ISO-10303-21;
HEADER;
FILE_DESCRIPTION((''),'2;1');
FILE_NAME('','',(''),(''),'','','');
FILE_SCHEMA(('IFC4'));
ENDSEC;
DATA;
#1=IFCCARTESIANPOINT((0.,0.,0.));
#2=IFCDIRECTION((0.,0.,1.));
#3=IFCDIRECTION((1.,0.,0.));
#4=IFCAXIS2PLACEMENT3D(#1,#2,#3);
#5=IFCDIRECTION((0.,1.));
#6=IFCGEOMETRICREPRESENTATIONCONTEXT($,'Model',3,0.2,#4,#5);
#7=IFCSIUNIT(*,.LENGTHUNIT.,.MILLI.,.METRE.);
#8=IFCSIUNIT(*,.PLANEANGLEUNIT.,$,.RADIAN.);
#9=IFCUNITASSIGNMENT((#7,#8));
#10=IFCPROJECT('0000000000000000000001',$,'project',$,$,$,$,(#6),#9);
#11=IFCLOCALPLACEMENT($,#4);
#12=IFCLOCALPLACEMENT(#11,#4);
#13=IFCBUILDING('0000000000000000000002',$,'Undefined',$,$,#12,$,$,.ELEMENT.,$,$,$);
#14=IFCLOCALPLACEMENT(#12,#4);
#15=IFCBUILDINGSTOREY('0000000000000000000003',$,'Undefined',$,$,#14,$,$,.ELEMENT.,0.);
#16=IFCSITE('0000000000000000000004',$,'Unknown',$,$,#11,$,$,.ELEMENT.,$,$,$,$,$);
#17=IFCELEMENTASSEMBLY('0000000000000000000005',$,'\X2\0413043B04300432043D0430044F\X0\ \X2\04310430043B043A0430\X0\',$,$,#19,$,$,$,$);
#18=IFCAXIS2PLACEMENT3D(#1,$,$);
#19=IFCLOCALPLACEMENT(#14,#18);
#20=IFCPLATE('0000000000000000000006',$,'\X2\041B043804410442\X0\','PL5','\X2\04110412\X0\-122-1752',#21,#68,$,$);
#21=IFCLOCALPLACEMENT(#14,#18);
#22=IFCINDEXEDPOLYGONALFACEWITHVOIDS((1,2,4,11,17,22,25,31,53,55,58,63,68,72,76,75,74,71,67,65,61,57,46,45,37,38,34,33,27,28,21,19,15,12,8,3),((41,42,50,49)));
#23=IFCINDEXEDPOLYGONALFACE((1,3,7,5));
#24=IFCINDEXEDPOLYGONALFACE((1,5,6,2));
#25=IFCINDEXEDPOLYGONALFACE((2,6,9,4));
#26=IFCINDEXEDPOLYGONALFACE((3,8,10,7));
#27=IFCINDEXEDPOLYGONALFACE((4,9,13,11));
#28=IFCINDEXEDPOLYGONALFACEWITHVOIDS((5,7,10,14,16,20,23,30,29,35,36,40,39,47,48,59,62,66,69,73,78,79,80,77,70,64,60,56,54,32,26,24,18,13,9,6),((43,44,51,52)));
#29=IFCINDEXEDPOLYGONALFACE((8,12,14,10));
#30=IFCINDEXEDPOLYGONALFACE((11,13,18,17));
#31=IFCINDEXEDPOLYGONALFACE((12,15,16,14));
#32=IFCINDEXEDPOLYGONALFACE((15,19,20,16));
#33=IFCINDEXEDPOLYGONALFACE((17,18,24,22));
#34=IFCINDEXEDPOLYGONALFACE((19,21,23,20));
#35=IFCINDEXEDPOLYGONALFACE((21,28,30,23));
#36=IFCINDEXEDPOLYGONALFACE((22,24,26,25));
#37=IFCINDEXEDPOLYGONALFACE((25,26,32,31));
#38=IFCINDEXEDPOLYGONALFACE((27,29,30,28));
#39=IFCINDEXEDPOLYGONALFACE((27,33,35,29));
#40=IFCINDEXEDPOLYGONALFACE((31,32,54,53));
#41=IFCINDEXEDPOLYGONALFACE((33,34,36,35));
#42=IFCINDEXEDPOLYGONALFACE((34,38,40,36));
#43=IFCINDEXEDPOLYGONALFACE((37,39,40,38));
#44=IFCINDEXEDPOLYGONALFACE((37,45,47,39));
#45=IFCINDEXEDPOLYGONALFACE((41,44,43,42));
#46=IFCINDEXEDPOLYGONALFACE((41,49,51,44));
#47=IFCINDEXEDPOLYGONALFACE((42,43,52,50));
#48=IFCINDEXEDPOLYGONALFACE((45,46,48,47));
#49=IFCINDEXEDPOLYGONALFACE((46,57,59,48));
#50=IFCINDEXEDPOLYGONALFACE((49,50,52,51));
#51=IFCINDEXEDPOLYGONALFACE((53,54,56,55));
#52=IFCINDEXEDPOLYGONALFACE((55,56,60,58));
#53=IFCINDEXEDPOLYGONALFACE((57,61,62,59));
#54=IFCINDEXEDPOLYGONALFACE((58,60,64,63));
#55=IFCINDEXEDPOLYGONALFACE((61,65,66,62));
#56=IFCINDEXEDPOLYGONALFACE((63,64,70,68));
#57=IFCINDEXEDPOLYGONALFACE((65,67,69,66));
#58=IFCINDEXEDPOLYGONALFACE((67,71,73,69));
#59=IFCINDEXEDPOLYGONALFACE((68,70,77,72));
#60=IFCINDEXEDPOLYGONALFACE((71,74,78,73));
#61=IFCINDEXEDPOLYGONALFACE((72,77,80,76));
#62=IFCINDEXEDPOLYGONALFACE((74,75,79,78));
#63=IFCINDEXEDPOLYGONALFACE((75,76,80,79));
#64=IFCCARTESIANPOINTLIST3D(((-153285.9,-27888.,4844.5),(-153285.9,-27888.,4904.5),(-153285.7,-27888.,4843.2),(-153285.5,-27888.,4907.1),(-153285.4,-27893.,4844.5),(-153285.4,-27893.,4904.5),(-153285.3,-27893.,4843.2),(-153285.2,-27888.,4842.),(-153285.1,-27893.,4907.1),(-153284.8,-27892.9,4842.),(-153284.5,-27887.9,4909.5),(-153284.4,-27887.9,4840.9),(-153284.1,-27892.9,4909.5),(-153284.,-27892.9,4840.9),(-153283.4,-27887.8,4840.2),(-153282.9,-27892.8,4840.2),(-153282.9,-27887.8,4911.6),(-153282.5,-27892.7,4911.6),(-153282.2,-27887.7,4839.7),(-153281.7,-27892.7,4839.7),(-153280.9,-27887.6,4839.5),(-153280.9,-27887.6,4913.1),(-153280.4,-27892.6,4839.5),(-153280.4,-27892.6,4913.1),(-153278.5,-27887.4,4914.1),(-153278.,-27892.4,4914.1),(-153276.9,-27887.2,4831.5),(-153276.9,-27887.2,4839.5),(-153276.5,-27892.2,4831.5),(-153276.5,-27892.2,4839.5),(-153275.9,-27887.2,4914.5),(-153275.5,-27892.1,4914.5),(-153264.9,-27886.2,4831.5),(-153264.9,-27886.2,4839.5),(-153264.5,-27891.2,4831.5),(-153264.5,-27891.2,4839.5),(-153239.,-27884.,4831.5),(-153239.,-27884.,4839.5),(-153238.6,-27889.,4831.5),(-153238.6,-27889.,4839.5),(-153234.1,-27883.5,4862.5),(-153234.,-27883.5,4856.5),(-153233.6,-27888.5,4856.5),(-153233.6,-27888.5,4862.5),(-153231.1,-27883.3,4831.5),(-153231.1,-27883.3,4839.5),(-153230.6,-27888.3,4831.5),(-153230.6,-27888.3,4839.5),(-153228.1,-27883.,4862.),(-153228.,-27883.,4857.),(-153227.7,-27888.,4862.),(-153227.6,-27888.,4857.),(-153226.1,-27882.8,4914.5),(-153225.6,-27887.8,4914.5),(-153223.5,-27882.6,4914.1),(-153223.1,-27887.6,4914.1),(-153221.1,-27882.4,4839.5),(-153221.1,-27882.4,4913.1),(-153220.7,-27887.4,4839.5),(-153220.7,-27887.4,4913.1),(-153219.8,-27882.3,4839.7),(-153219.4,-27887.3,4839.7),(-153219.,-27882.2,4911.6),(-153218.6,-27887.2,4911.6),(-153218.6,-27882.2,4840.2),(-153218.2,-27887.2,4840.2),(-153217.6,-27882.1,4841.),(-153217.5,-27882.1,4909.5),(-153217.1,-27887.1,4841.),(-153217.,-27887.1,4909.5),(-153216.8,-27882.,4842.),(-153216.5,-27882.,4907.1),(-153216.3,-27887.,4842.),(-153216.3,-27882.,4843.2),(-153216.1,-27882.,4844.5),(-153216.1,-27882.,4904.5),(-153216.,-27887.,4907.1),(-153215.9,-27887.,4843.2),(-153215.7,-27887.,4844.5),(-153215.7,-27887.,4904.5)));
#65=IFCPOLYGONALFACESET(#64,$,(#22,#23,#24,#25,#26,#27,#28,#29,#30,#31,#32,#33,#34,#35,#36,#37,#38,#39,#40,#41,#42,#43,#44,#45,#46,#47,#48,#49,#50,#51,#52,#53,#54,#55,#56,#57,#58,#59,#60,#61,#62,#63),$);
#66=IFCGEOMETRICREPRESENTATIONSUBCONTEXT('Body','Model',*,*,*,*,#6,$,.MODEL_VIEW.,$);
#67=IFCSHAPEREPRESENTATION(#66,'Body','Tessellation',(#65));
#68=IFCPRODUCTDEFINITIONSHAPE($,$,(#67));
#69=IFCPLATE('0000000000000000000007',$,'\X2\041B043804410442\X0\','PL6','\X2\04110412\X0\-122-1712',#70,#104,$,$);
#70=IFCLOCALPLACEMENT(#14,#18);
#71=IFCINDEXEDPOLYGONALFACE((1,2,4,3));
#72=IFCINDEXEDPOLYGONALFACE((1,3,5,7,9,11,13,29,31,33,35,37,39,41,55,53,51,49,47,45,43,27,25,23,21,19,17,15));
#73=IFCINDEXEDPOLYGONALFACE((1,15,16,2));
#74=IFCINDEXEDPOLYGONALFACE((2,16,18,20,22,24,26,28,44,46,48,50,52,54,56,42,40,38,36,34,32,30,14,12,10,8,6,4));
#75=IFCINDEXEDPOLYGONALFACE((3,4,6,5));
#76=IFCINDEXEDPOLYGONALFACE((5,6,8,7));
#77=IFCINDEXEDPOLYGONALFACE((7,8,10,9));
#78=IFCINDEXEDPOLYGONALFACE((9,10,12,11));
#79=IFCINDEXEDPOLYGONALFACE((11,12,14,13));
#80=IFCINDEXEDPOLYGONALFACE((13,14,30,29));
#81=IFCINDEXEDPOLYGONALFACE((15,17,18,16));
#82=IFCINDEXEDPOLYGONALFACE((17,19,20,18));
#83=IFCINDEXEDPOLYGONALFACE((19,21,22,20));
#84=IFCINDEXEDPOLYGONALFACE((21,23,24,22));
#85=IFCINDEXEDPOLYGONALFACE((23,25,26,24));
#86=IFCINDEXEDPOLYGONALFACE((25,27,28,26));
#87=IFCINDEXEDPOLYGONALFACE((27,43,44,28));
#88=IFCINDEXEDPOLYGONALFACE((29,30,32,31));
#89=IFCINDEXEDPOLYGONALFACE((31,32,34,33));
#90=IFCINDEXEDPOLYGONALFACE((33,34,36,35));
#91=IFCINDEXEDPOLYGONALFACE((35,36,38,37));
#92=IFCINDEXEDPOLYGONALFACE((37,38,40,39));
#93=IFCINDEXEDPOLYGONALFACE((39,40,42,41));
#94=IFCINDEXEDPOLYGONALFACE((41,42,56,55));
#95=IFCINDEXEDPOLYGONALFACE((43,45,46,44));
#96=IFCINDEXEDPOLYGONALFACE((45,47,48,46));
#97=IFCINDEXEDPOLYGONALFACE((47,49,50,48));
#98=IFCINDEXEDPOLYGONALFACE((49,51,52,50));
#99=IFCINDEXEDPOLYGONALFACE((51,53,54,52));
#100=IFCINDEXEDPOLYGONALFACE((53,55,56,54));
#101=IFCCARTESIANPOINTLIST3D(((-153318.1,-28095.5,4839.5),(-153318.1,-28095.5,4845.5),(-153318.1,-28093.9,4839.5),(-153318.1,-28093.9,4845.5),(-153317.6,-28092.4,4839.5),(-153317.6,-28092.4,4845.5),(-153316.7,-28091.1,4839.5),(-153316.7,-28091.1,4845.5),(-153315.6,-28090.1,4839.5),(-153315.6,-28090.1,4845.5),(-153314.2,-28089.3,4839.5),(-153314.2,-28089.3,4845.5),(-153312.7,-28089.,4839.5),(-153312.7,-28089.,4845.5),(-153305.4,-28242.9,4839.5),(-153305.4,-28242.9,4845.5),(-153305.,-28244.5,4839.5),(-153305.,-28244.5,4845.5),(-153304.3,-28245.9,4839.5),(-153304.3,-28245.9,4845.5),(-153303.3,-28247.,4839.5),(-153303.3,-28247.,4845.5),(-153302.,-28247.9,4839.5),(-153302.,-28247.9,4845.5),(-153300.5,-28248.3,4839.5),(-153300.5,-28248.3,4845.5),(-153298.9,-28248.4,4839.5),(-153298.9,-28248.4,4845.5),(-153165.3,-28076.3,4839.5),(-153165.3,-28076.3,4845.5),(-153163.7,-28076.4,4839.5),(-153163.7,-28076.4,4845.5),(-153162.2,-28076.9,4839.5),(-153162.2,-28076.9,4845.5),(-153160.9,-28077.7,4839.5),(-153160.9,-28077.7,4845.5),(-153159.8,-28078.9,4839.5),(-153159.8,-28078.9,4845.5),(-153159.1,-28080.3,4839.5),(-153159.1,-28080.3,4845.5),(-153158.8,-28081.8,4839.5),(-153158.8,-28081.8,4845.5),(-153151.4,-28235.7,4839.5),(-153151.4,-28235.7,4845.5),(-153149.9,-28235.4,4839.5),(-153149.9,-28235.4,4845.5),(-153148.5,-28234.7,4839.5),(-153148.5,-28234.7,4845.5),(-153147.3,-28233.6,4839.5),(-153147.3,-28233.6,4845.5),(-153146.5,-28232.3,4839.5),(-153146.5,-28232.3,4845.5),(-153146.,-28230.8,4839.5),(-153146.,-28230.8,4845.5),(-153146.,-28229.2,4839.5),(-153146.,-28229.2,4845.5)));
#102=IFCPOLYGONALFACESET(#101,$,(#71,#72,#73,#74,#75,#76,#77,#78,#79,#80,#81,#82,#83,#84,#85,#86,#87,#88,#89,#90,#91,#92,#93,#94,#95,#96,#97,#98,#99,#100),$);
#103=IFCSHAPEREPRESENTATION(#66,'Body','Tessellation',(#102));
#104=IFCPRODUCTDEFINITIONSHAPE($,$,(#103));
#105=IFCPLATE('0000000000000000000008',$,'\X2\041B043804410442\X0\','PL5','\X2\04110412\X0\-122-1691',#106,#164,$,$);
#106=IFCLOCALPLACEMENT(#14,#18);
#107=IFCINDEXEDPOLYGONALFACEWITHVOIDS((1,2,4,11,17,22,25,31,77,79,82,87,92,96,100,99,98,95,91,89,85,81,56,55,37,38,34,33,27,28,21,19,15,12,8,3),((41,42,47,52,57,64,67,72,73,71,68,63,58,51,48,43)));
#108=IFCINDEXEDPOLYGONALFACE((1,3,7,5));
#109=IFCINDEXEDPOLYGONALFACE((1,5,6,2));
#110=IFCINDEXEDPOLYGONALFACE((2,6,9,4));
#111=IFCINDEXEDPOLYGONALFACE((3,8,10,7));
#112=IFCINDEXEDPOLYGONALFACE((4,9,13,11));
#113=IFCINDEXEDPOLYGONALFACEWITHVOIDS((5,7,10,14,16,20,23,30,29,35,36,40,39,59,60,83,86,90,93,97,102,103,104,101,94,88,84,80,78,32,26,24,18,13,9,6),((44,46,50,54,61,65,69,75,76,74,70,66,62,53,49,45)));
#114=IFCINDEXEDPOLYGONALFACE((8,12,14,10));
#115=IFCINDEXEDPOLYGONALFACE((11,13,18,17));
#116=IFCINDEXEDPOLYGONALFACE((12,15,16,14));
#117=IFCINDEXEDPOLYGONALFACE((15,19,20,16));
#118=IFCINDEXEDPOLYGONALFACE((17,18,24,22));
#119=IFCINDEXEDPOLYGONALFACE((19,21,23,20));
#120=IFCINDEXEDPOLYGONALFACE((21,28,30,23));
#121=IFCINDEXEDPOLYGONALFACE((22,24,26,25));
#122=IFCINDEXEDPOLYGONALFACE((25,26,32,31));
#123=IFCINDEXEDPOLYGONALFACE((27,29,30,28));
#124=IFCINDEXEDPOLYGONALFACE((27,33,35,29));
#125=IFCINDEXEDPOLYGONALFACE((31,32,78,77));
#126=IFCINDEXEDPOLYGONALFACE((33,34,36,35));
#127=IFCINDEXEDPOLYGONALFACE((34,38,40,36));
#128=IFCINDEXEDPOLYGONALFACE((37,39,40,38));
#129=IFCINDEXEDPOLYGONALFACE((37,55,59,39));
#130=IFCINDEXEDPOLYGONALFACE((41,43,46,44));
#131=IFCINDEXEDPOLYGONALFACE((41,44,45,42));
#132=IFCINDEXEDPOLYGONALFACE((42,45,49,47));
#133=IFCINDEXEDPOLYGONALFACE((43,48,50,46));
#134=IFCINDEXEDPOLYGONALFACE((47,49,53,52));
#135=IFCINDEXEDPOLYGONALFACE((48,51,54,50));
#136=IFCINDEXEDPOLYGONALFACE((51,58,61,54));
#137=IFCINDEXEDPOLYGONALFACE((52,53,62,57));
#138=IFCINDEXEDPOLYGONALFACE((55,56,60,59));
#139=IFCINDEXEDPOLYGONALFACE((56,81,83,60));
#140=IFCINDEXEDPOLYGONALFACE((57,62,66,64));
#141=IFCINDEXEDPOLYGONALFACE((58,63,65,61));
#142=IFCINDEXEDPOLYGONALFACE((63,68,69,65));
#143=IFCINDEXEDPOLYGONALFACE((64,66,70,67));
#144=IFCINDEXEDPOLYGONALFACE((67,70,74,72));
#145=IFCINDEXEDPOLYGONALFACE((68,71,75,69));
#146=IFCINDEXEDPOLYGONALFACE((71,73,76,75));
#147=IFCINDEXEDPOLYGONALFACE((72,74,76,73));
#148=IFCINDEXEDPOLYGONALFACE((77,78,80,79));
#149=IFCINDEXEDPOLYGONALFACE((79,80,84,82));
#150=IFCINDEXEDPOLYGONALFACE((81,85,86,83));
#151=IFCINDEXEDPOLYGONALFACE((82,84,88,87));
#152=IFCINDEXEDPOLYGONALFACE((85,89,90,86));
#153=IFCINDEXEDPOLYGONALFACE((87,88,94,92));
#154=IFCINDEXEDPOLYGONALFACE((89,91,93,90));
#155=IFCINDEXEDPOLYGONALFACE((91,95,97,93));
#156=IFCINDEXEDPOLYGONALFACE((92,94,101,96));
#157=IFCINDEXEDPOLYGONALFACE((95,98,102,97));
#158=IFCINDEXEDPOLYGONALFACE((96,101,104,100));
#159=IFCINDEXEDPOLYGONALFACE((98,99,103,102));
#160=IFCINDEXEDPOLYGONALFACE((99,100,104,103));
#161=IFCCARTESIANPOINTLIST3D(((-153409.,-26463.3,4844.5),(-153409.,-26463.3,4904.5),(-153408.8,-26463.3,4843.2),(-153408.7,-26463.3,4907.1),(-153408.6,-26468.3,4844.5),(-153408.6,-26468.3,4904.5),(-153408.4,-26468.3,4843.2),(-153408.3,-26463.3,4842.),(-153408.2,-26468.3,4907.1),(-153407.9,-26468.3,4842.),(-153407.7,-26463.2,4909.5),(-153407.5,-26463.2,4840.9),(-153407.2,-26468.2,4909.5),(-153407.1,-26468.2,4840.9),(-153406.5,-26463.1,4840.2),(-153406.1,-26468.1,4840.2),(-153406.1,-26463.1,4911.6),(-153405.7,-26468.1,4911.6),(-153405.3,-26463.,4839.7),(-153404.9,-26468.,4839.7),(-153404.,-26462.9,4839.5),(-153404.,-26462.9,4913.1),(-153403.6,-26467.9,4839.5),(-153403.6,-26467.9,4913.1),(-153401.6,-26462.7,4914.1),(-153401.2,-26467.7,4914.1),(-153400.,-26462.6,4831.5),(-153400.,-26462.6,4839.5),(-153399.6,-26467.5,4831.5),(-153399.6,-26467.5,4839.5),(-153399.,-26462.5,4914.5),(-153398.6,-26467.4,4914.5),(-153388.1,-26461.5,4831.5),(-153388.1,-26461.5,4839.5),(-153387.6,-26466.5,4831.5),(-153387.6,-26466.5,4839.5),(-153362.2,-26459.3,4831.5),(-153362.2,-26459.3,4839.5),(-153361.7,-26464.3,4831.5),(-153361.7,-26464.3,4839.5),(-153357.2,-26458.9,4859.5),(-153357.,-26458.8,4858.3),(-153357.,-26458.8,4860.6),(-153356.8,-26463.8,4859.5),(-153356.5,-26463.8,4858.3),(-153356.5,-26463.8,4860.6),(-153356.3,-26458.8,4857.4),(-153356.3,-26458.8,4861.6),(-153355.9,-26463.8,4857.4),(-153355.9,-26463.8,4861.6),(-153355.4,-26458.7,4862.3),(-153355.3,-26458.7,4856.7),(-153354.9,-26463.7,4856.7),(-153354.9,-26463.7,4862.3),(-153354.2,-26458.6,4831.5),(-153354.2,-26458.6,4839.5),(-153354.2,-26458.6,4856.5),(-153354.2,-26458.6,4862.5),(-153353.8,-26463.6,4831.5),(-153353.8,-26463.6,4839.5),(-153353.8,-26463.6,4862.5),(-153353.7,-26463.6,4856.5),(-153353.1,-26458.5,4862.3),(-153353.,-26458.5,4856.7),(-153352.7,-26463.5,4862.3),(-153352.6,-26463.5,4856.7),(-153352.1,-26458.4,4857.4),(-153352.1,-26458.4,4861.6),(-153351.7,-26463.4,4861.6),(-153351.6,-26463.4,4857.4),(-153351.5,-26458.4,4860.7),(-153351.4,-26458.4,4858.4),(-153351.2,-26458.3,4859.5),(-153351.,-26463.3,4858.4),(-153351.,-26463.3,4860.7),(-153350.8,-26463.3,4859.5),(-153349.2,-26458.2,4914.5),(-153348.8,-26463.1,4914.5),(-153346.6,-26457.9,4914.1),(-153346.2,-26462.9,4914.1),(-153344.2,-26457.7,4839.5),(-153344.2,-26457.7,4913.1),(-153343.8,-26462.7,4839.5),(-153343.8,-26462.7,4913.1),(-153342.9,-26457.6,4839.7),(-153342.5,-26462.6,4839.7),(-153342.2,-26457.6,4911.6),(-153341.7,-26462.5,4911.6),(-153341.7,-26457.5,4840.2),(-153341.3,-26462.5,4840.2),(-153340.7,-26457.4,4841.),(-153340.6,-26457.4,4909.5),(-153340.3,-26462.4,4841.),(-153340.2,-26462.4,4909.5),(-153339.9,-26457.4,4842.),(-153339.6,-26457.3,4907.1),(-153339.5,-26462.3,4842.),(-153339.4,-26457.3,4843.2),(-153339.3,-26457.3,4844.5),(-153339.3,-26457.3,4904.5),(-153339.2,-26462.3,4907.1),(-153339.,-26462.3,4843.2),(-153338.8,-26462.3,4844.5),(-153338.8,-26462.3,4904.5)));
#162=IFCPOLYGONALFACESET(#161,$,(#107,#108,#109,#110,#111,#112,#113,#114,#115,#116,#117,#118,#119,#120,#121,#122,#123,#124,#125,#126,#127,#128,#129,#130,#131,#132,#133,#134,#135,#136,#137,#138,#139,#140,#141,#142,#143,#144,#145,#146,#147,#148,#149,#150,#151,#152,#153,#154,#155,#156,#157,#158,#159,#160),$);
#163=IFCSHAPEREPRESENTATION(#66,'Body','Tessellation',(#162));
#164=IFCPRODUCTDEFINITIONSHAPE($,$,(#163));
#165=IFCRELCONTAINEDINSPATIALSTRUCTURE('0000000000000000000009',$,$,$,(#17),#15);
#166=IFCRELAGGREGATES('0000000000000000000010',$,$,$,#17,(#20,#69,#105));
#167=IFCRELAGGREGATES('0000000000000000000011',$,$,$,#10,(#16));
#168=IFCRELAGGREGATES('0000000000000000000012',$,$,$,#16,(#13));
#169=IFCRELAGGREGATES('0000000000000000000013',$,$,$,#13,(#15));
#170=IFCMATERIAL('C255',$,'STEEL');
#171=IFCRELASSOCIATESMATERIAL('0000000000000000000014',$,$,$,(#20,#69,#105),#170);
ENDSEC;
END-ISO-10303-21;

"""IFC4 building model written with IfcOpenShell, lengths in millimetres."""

from ifc_helpers import new_model, si_unit, direction, frame, origin_with_axes, place, context, subcontext, project, spatial, line, arc, indexed_curve, outline, extrude, material, element, aggregate, save


model = new_model("IFC4")

# Units and contexts
model_context = context("Model", 3, precision=0.2, world=origin_with_axes(), true_north=direction((0.0, 1.0)))
body_context = subcontext(model_context, "Body", "Model", "MODEL_VIEW")
ifc_project = project(units=[si_unit("LENGTHUNIT", "METRE", prefix="MILLI"), si_unit("PLANEANGLEUNIT", "RADIAN")], contexts=[model_context])

# Site, building, storey
site_placement = place(None, origin_with_axes())
site = spatial("IfcSite", under=ifc_project, at=site_placement, Name="Unknown", CompositionType="ELEMENT")
building_placement = place(site_placement, origin_with_axes())
building = spatial("IfcBuilding", under=site, at=building_placement, Name="Undefined", CompositionType="ELEMENT")
storey_placement = place(building_placement, origin_with_axes())
storey = spatial("IfcBuildingStorey", under=building, at=storey_placement, Name="Undefined", CompositionType="ELEMENT", Elevation=0.0)

# Shared definitions
ifc_material_1 = material(Name="C255", Category="STEEL")

# Element assembly, plates, voiding features
assembly_1_placement = place(storey_placement, frame((-153222.7, -28270.2, 4779.5), z_axis=(-0.996286, -0.086101, -0.000024), x_axis=(-0.086101, 0.996286, 0.0)))
assembly_1 = element("IfcElementAssembly", 1, at=assembly_1_placement, inside=storey, Name="Главная балка")
plate_1_placement = place(assembly_1_placement, frame((383.7, -135.0, -40.0), z_axis=(-1.0, -0.000054, -0.000013), x_axis=(-0.000013, 0.000054, 1.0)))
plate_1 = element("IfcPlate", 2, at=plate_1_placement, material=ifc_material_1, Name="Лист", Description="PL5", ObjectType="БВ-122-1752", context=body_context, shape_type="SolidModel", body=[
    extrude(outline(indexed_curve([(0.0, 10.0), (2.9, 2.9), (10.0, 0.0), (60.0, 0.0), (67.1, 2.9), (70.0, 10.0), (70.0, 70.0), (68.5, 73.5), (65.0, 75.0), (61.0, 75.0), (61.0, 83.0), (49.0, 83.0), (49.0, 75.0), (23.0, 75.0), (23.0, 83.0), (15.0, 83.0), (15.0, 75.0), (5.0, 75.0), (1.5, 73.5), (0.0, 70.0)], segments=[arc(1, 2, 3), line(3, 4), arc(4, 5, 6), line(6, 7), arc(7, 8, 9), line(9, 10, 11, 12, 13, 14, 15, 16, 17, 18), arc(18, 19, 20), line(20, 1)])), frame((0.0, 0.0, 2.5), z_axis=(0.0, 0.0, 1.0), x_axis=(1.0, 0.0, 0.0)), (0.0, 0.0, -1.0), 5.0),
])
voiding_feature_1_placement = place(plate_1_placement, frame((15.0, 55.0, 10.0), z_axis=(0.007997, -0.999968, -0.000026), x_axis=(0.0, 0.000026, -1.0)))
element("IfcVoidingFeature", 3, at=voiding_feature_1_placement, cuts=plate_1, Name="Балка", ObjectType="(?)", PredefinedType="HOLE", context=body_context, shape_type="SolidModel", body=[
    extrude(outline(indexed_curve([(2.5, -3.0), (3.0, 3.0), (-3.0, 3.0), (-2.5, -3.0)], segments=[line(1, 2, 3, 4, 1)])), frame((0.0, 0.0, 0.0), z_axis=(-1.0, 0.0, 0.0), x_axis=(0.0, 0.0, 1.0)), (0.0, 0.0, -1.0), 20.0),
])
plate_2_placement = place(assembly_1_placement, frame((28.2, -63.0, -80.0), z_axis=(0.0, -1.0, 0.0), x_axis=(1.0, 0.0, 0.00038)))
plate_2 = element("IfcPlate", 4, at=plate_2_placement, material=ifc_material_1, Name="Лист", Description="PL6", ObjectType="БВ-122-1712", context=body_context, shape_type="SolidModel", body=[
    extrude(outline(indexed_curve([(0.0, 6.0), (1.8, 1.8), (6.0, 0.0), (154.0, 0.0), (158.2, 1.8), (160.0, 6.0), (160.1, 154.0), (158.4, 158.2), (154.1, 160.0), (6.1, 160.0), (1.9, 158.3), (0.1, 154.0)], segments=[arc(1, 2, 3), line(3, 4), arc(4, 5, 6), line(6, 7), arc(7, 8, 9), line(9, 10), arc(10, 11, 12), line(12, 1)])), frame((0.0, 0.0, 3.0), z_axis=(0.0, 0.0, 1.0), x_axis=(1.0, 0.0, 0.0)), (0.0, 0.0, -1.0), 6.0),
])
plate_3_placement = place(assembly_1_placement, frame((1813.7, -135.0, -40.0), z_axis=(-1.0, -0.000054, -0.000013), x_axis=(-0.000013, 0.000054, 1.0)))
plate_3 = element("IfcPlate", 5, at=plate_3_placement, material=ifc_material_1, Name="Лист", Description="PL5", ObjectType="БВ-122-1691", context=body_context, shape_type="SolidModel", body=[
    extrude(outline(indexed_curve([(0.0, 10.0), (2.9, 2.9), (10.0, 0.0), (60.0, 0.0), (67.1, 2.9), (70.0, 10.0), (70.0, 70.0), (68.5, 73.5), (65.0, 75.0), (61.0, 75.0), (61.0, 83.0), (49.0, 83.0), (49.0, 75.0), (23.0, 75.0), (23.0, 83.0), (15.0, 83.0), (15.0, 75.0), (5.0, 75.0), (1.5, 73.5), (0.0, 70.0)], segments=[arc(1, 2, 3), line(3, 4), arc(4, 5, 6), line(6, 7), arc(7, 8, 9), line(9, 10, 11, 12, 13, 14, 15, 16, 17, 18), arc(18, 19, 20), line(20, 1)])), frame((0.0, 0.0, 2.5), z_axis=(0.0, 0.0, 1.0), x_axis=(1.0, 0.0, 0.0)), (0.0, 0.0, -1.0), 5.0),
])
voiding_feature_2_placement = place(plate_3_placement, frame((15.0, 55.0, 10.0), z_axis=(0.007997, -0.999968, -0.000026), x_axis=(0.0, 0.000026, -1.0)))
element("IfcVoidingFeature", 6, at=voiding_feature_2_placement, cuts=plate_3, Name="Балка", ObjectType="(?)", PredefinedType="HOLE", context=body_context, shape_type="SolidModel", body=[
    extrude(outline(indexed_curve([(3.0, 0.0), (2.8, 1.1), (2.1, 2.1), (1.1, 2.8), (0.0, 3.0), (-1.1, 2.8), (-2.1, 2.1), (-2.8, 1.1), (-3.0, 0.0), (-2.8, -1.1), (-2.1, -2.1), (-1.1, -2.8), (0.0, -3.0), (1.1, -2.8), (2.1, -2.1), (2.8, -1.1)], segments=[line(1, 2, 3, 4, 5, 6, 7, 8, 9, 10, 11, 12, 13, 14, 15, 16, 1)])), frame((0.0, 0.0, 0.0), z_axis=(-1.0, 0.0, 0.0), x_axis=(0.0, 0.0, 1.0)), (0.0, 0.0, -1.0), 20.0),
])

aggregate(assembly_1, [plate_1, plate_2, plate_3])

save(model, "model.ifc")
